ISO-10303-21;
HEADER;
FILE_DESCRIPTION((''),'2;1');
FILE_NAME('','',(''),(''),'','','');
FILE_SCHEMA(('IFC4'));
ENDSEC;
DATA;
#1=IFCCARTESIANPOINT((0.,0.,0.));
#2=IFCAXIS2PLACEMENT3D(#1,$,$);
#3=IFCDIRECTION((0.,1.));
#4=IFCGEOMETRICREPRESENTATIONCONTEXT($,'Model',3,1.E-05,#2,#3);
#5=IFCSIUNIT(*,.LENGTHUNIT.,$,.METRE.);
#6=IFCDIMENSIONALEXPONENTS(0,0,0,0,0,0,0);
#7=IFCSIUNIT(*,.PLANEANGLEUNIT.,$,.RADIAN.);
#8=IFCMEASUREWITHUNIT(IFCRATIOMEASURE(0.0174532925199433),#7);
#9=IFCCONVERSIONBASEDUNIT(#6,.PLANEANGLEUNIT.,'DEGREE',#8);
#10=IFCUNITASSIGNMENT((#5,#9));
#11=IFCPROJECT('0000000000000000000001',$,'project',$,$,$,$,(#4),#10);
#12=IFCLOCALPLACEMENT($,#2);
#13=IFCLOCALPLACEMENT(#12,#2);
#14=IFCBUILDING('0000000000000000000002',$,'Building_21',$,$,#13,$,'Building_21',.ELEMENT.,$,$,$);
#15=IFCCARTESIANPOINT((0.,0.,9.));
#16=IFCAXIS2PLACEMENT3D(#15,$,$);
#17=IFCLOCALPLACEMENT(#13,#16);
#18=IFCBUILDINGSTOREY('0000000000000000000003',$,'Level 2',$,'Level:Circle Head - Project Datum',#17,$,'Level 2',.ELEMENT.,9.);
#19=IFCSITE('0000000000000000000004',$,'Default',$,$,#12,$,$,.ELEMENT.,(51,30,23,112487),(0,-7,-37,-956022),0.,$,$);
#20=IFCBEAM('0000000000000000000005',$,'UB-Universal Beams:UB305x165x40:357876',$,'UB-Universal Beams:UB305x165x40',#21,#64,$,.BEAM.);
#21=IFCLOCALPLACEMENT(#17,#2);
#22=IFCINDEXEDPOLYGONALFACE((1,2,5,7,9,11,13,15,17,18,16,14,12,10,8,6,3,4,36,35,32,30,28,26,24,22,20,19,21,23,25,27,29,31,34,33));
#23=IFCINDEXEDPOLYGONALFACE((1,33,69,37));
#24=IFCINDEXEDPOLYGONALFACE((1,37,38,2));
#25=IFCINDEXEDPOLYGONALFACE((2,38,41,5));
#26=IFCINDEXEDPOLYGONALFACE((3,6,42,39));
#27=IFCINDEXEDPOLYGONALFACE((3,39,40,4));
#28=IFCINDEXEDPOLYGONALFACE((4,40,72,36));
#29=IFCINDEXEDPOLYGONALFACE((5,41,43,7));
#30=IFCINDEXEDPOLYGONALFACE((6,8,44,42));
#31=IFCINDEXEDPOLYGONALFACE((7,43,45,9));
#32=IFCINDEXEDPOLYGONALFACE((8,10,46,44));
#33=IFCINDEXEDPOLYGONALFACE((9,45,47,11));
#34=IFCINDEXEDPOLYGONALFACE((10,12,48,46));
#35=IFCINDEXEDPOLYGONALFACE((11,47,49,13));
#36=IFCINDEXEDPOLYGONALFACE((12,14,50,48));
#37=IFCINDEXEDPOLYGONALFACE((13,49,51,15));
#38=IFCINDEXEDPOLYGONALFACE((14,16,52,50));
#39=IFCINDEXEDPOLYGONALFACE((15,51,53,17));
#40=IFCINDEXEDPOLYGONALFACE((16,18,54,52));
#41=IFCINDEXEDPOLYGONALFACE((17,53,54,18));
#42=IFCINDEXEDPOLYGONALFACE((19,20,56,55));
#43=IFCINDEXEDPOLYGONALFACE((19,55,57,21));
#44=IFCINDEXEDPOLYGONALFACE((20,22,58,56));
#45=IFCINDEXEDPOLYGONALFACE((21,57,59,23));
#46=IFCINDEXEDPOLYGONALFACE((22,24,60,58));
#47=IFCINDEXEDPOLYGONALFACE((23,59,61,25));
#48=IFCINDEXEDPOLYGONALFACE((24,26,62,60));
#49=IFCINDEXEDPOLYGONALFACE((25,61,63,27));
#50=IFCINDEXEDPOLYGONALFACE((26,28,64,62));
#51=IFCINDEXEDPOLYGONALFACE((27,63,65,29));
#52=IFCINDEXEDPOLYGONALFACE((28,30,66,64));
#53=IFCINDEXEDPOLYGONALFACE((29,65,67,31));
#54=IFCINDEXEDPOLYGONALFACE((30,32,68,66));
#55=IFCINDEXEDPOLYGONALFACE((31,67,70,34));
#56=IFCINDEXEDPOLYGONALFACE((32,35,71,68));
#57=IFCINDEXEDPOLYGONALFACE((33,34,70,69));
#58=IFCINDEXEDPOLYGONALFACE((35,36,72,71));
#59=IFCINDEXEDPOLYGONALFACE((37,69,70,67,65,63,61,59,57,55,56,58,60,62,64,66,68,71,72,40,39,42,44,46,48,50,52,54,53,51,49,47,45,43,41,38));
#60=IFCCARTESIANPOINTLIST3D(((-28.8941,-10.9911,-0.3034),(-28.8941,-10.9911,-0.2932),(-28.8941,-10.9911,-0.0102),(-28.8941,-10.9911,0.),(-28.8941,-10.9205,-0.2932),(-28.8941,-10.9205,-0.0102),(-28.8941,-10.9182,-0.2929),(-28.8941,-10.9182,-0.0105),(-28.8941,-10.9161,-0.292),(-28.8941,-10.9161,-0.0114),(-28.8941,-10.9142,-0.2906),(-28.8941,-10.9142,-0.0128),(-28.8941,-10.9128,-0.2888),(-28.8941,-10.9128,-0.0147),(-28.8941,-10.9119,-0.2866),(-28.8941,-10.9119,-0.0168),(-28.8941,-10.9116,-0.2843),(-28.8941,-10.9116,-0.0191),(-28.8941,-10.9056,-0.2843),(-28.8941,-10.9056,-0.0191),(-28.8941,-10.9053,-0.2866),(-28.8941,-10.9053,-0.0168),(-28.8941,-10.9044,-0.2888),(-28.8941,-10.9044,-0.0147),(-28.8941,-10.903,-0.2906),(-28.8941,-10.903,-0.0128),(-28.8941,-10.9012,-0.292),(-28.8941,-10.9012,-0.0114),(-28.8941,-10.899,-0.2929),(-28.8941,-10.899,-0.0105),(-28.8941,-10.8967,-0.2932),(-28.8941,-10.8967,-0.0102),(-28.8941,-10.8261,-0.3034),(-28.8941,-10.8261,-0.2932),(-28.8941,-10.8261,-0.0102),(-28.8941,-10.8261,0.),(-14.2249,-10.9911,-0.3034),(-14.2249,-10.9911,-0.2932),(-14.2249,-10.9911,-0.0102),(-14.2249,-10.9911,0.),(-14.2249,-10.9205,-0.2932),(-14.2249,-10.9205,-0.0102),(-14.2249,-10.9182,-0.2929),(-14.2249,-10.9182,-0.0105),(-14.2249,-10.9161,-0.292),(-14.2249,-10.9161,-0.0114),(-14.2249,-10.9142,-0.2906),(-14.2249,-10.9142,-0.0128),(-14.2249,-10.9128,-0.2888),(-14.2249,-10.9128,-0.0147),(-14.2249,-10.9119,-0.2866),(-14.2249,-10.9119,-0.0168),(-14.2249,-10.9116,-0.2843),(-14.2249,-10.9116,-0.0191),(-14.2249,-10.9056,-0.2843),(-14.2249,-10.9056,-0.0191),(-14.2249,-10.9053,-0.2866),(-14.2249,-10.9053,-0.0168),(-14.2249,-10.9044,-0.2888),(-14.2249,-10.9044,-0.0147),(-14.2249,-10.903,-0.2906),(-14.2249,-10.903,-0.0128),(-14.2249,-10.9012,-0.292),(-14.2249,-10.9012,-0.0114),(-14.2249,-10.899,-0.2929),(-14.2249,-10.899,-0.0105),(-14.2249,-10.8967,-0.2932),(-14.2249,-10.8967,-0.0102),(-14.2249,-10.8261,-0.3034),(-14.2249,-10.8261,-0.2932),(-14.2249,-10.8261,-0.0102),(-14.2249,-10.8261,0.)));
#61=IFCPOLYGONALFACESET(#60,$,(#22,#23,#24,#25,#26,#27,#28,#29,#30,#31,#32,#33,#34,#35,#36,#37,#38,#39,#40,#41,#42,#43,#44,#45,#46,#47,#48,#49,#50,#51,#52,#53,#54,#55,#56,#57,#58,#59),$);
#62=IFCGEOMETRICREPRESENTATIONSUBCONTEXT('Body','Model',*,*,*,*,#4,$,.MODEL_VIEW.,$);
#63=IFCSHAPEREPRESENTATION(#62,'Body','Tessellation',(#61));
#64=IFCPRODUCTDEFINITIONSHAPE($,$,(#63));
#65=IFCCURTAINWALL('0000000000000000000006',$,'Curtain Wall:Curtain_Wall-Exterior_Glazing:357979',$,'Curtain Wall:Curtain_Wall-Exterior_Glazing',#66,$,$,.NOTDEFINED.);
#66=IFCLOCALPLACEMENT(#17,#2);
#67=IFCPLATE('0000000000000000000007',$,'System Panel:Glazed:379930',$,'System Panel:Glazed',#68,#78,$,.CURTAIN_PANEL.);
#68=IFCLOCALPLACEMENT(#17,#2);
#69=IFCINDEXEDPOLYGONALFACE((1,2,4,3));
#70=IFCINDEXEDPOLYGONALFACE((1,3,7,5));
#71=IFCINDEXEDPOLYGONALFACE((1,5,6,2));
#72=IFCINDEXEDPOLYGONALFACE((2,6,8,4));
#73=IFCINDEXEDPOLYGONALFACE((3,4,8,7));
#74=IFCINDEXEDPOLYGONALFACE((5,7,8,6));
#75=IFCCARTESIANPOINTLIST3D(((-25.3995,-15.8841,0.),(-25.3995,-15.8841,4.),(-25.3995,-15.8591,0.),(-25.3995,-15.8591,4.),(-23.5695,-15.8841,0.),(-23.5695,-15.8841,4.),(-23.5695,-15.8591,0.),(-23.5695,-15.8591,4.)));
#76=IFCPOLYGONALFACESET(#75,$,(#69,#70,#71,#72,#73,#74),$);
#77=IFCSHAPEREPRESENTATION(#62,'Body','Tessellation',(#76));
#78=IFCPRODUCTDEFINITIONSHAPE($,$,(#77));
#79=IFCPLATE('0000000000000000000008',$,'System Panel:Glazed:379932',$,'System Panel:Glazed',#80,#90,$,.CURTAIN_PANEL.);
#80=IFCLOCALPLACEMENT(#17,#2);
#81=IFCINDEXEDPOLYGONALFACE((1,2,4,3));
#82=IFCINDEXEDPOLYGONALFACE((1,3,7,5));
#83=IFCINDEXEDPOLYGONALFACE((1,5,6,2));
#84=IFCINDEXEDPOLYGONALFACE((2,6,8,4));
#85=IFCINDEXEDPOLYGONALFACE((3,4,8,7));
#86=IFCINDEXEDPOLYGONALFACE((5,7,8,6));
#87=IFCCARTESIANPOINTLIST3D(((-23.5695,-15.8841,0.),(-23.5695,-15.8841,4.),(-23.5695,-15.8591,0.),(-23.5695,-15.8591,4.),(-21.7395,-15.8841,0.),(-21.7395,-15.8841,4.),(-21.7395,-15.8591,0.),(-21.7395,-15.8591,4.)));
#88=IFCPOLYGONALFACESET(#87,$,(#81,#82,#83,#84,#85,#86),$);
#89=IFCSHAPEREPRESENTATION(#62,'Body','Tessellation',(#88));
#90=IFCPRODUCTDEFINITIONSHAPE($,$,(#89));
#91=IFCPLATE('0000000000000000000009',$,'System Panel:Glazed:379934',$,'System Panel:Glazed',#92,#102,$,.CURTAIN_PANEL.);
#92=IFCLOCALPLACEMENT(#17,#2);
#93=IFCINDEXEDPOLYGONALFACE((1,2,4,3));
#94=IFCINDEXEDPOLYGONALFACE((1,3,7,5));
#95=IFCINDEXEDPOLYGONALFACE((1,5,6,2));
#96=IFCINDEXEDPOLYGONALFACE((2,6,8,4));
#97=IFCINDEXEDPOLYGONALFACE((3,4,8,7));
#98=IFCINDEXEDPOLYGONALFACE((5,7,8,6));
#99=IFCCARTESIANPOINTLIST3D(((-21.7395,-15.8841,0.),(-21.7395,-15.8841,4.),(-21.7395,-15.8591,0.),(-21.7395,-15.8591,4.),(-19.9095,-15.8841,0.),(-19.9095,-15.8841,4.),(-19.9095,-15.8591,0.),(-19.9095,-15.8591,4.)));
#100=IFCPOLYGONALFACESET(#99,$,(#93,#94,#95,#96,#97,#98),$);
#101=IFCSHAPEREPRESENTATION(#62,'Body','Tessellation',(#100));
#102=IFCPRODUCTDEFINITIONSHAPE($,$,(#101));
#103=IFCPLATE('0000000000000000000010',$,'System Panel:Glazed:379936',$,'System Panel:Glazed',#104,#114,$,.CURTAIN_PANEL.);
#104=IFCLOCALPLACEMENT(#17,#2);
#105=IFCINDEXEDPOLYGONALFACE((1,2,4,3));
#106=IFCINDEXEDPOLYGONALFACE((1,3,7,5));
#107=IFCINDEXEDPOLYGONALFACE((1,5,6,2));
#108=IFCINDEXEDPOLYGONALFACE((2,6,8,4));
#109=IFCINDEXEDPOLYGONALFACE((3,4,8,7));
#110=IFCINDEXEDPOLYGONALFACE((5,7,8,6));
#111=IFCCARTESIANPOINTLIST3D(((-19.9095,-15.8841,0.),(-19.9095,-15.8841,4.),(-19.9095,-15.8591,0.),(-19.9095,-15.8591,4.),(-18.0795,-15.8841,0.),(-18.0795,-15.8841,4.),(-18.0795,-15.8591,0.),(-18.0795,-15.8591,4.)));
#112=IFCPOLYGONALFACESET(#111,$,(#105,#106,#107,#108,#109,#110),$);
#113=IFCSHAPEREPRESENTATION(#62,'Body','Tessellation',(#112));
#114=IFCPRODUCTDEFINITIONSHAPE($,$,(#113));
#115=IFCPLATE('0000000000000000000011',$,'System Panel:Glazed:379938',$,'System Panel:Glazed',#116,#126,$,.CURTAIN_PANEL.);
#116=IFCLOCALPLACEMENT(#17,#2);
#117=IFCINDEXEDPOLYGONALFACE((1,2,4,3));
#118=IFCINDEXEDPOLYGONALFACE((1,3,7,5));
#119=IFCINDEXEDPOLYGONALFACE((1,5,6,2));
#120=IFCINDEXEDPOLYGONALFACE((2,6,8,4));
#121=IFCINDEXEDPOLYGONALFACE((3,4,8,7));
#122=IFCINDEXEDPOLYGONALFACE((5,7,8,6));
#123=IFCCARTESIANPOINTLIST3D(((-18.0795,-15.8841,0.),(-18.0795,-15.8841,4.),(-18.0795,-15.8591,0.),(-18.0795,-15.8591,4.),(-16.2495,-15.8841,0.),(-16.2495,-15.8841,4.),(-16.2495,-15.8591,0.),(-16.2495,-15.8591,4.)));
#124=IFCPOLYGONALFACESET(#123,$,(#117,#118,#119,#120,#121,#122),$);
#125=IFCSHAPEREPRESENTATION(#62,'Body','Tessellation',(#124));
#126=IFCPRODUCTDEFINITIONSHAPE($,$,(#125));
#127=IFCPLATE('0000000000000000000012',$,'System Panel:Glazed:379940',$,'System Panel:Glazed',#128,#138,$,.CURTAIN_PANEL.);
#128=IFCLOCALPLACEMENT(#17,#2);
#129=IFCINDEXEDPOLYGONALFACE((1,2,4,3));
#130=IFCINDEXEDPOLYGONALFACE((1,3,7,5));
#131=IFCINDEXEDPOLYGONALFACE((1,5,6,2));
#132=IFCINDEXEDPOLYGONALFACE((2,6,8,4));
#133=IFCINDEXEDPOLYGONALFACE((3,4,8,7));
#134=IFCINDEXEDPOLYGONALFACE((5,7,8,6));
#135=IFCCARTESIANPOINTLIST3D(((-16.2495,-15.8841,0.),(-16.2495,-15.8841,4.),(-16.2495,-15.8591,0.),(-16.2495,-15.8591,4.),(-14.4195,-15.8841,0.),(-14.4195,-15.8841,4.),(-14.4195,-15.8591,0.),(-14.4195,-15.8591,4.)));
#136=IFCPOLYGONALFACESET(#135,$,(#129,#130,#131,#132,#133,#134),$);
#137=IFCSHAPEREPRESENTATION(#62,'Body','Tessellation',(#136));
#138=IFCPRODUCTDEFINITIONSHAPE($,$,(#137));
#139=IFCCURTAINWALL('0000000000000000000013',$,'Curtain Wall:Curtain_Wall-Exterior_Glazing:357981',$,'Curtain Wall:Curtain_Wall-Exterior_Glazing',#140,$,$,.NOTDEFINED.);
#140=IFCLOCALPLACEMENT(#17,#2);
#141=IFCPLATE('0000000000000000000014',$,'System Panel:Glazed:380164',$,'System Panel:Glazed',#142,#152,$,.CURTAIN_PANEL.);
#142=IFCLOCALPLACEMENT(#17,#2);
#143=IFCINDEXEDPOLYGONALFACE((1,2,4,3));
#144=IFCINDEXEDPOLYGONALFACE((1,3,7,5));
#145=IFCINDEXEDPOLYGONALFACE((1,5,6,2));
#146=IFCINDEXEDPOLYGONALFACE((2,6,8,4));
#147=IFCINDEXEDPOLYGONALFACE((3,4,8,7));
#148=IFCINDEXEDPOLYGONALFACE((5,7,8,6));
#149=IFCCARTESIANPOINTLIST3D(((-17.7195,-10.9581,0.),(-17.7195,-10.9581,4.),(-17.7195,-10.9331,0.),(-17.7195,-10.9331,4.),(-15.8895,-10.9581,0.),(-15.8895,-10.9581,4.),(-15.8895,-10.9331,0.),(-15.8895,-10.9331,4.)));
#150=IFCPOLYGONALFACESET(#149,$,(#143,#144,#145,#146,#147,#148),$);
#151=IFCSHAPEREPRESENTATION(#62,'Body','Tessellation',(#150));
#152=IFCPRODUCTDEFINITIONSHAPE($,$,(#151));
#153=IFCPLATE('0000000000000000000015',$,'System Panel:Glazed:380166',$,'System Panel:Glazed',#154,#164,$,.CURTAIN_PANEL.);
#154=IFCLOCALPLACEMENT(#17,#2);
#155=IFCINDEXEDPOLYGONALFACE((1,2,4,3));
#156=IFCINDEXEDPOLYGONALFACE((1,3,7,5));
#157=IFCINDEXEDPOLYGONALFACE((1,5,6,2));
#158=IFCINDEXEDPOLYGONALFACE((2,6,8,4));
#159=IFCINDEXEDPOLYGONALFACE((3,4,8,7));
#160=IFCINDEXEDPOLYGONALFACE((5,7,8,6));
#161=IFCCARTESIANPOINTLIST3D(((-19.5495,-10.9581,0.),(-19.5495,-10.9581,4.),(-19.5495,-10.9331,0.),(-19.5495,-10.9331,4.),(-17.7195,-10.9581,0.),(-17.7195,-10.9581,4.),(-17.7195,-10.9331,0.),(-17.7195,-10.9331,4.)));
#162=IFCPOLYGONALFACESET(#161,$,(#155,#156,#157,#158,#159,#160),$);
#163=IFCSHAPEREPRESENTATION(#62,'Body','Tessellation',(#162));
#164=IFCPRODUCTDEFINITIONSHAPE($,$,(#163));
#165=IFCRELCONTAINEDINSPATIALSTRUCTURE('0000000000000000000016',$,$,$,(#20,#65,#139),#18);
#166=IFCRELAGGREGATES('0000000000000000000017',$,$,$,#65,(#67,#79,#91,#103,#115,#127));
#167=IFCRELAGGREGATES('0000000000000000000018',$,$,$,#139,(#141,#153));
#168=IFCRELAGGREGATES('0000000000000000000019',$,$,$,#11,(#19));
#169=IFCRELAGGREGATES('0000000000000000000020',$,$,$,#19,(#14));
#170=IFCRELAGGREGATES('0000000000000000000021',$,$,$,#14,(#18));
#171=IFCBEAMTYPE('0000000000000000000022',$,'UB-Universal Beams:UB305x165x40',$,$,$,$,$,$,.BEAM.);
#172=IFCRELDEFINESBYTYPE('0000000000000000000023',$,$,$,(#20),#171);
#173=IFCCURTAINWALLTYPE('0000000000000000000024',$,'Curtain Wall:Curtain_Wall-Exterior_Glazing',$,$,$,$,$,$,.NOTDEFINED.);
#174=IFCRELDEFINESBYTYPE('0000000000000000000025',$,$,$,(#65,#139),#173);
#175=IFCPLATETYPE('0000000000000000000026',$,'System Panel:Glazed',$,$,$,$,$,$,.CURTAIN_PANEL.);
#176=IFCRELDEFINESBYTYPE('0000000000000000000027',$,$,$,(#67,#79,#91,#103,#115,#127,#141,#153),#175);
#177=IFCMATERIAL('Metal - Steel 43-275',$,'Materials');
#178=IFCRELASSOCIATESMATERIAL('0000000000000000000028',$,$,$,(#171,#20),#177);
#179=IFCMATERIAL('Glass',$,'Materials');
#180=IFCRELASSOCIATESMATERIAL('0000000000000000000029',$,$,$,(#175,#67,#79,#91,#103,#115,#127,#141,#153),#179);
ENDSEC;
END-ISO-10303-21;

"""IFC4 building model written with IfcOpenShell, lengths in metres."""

from ifc_helpers import new_model, entity, si_unit, converted_unit, direction, frame, frame_2d, origin, origin_2d_with_axis, place, context, subcontext, project, spatial, polyline, circle_curve, parameter, trimmed, segment, composite_curve, rectangle, i_section, outline, extrude, source, transform, mapped, material, material_profile, profile_set, profile_usage, type_object, type_shapes, element, aggregate, save


model = new_model("IFC4")

# Units and contexts
model_context = context("Model", 3, precision=1e-05, world=origin(), true_north=direction((0.0, 1.0)))
body_context = subcontext(model_context, "Body", "Model", "MODEL_VIEW")
ifc_project = project(units=[si_unit("LENGTHUNIT", "METRE"), converted_unit("PLANEANGLEUNIT", "DEGREE", entity("IfcRatioMeasure", 0.0174532925199433), si_unit("PLANEANGLEUNIT", "RADIAN"), dimensions=[0, 0, 0, 0, 0, 0, 0])], contexts=[model_context])

# Site, building, storey
site_placement = place(None, origin())
site = spatial("IfcSite", under=ifc_project, at=site_placement, Name="Default", CompositionType="ELEMENT", RefLatitude=(51, 30, 23, 112487), RefLongitude=(0, -7, -37, -956022), RefElevation=0.0)
building_placement = place(site_placement, origin())
building = spatial("IfcBuilding", under=site, at=building_placement, Name="Building_21", LongName="Building_21", CompositionType="ELEMENT")
storey_placement = place(building_placement, frame((0.0, 0.0, 9.0)))
storey = spatial("IfcBuildingStorey", under=building, at=storey_placement, Name="Level 2", ObjectType="Level:Circle Head - Project Datum", LongName="Level 2", CompositionType="ELEMENT", Elevation=9.0)

# Shared definitions
ifc_material_1 = material(Name="Metal - Steel 43-275", Category="Materials")

# Beam
ifc_material_profile_1 = material_profile(ifc_material_1, outline(composite_curve([segment(polyline([(0.0119, -0.1415, 0.0), (0.0825, -0.1415, 0.0)]), True, "CONTINUOUS"), segment(polyline([(0.0825, -0.1415, 0.0), (0.0825, -0.1517, 0.0)]), True, "CONTINUOUS"), segment(polyline([(0.0825, -0.1517, 0.0), (-0.0825, -0.1517, 0.0)]), True, "CONTINUOUS"), segment(polyline([(-0.0825, -0.1517, 0.0), (-0.0825, -0.1415, 0.0)]), True, "CONTINUOUS"), segment(polyline([(-0.0825, -0.1415, 0.0), (-0.0119, -0.1415, 0.0)]), True, "CONTINUOUS"), segment(trimmed(circle_curve(frame((-0.0119, -0.1326, 0.0), z_axis=(0.0, 0.0, 1.0), x_axis=(-1.0, 0.0, 0.0)), 0.0089), [parameter(90.0)], [parameter(180.0)], True, "PARAMETER"), True, "CONTINUOUS"), segment(polyline([(-0.003, -0.1326, 0.0), (-0.003, 0.1326, 0.0)]), True, "CONTINUOUS"), segment(trimmed(circle_curve(frame((-0.0119, 0.1326, 0.0), z_axis=(0.0, 0.0, 1.0), x_axis=(-1.0, 0.0, 0.0)), 0.0089), [parameter(180.0)], [parameter(270.0)], True, "PARAMETER"), True, "CONTINUOUS"), segment(polyline([(-0.0119, 0.1415, 0.0), (-0.0825, 0.1415, 0.0)]), True, "CONTINUOUS"), segment(polyline([(-0.0825, 0.1415, 0.0), (-0.0825, 0.1517, 0.0)]), True, "CONTINUOUS"), segment(polyline([(-0.0825, 0.1517, 0.0), (0.0825, 0.1517, 0.0)]), True, "CONTINUOUS"), segment(polyline([(0.0825, 0.1517, 0.0), (0.0825, 0.1415, 0.0)]), True, "CONTINUOUS"), segment(polyline([(0.0825, 0.1415, 0.0), (0.0119, 0.1415, 0.0)]), True, "CONTINUOUS"), segment(trimmed(circle_curve(frame((0.0119, 0.1326, 0.0), z_axis=(0.0, 0.0, 1.0), x_axis=(-1.0, 0.0, 0.0)), 0.0089), [parameter(270.0)], [parameter(0.0)], True, "PARAMETER"), True, "CONTINUOUS"), segment(polyline([(0.003, 0.1326, 0.0), (0.003, -0.1326, 0.0)]), True, "CONTINUOUS"), segment(trimmed(circle_curve(frame((0.0119, -0.1326, 0.0), z_axis=(0.0, 0.0, 1.0), x_axis=(-1.0, 0.0, 0.0)), 0.0089), [parameter(0.0)], [parameter(90.0)], True, "PARAMETER"), True, "CONTINUOUS")], self_intersect=False), kind="CURVE"), Name="UB305x165x40")
ifc_material_profile_2 = material_profile(ifc_material_1, outline(composite_curve([segment(polyline([(-1.3346, 0.0825, -0.1415), (-1.3346, 0.0825, -0.1517)]), True, "CONTINUOUS"), segment(polyline([(-1.3346, 0.0825, -0.1517), (-1.3346, -0.0825, -0.1517)]), True, "CONTINUOUS"), segment(polyline([(-1.3346, -0.0825, -0.1517), (-1.3346, -0.0825, -0.1415)]), True, "CONTINUOUS"), segment(polyline([(-1.3346, -0.0825, -0.1415), (-1.3346, -0.003, -0.1415)]), True, "CONTINUOUS"), segment(polyline([(-1.3346, -0.003, -0.1415), (-1.3346, -0.003, 0.1415)]), True, "CONTINUOUS"), segment(polyline([(-1.3346, -0.003, 0.1415), (-1.3346, -0.0825, 0.1415)]), True, "CONTINUOUS"), segment(polyline([(-1.3346, -0.0825, 0.1415), (-1.3346, -0.0825, 0.1517)]), True, "CONTINUOUS"), segment(polyline([(-1.3346, -0.0825, 0.1517), (-1.3346, 0.0825, 0.1517)]), True, "CONTINUOUS"), segment(polyline([(-1.3346, 0.0825, 0.1517), (-1.3346, 0.0825, 0.1415)]), True, "CONTINUOUS"), segment(polyline([(-1.3346, 0.0825, 0.1415), (-1.3346, 0.003, 0.1415)]), True, "CONTINUOUS"), segment(polyline([(-1.3346, 0.003, 0.1415), (-1.3346, 0.003, -0.1415)]), True, "CONTINUOUS"), segment(polyline([(-1.3346, 0.003, -0.1415), (-1.3346, 0.0825, -0.1415)]), True, "CONTINUOUS")], self_intersect=False), kind="CURVE"), Name="UB305x165x40")
ifc_profile_set_1 = profile_set([ifc_material_profile_1, ifc_material_profile_2], Name="UB305x165x40")
ifc_profile_usage_1 = profile_usage(ifc_profile_set_1, cardinal=8)
beam_type_1 = type_object("IfcBeamType", Name="UB-Universal Beams:UB305x165x40", PredefinedType="BEAM", material=ifc_profile_set_1)
shared_shape_1 = source(origin(), body_context, "Body", "SweptSolid", [
    extrude(i_section(OverallWidth=0.165, OverallDepth=0.3034, WebThickness=0.006, FlangeThickness=0.0102, FilletRadius=0.0089, at=frame_2d((0.0, 0.0), x_axis=(0.0, 1.0))), frame((-7.3346, 0.0, 0.0), z_axis=(1.0, 0.0, 0.0), x_axis=(0.0, 0.0, -1.0)), (0.0, 0.0, 1.0), 14.6692),
])
type_shapes(beam_type_1, [shared_shape_1])
beam_1_placement = place(storey_placement, frame((-21.5595, -10.9086, -0.1517), z_axis=(0.0, 0.0, 1.0), x_axis=(-1.0, 0.0, 0.0)))
element("IfcBeam", 1, at=beam_1_placement, inside=storey, type_object=beam_type_1, material=ifc_profile_usage_1, Name="UB-Universal Beams:UB305x165x40:357876", ObjectType="UB-Universal Beams:UB305x165x40", PredefinedType="BEAM", context=body_context, shape_type="MappedRepresentation", body=[
    mapped(shared_shape_1, transform((0.0, 0.0, 0.0), scale=1.0)),
])

# Curtain walls, plates
curtain_wall_type = type_object("IfcCurtainWallType", Name="Curtain Wall:Curtain_Wall-Exterior_Glazing", PredefinedType="NOTDEFINED")
curtain_wall_1_placement = place(storey_placement, frame((0.0, 0.0, -9.0)))
curtain_wall_1 = element("IfcCurtainWall", 2, at=curtain_wall_1_placement, inside=storey, type_object=curtain_wall_type, Name="Curtain Wall:Curtain_Wall-Exterior_Glazing:357979", ObjectType="Curtain Wall:Curtain_Wall-Exterior_Glazing", PredefinedType="NOTDEFINED")
ifc_material_2 = material(Name="Glass", Category="Materials")
plate_type = type_object("IfcPlateType", Name="System Panel:Glazed", PredefinedType="CURTAIN_PANEL", material=ifc_material_2)
shared_shape_2 = source(origin(), body_context, "Body", "SweptSolid", [
    extrude(rectangle(XDim=0.025, YDim=1.83, at=origin_2d_with_axis()), frame((0.915, 0.0125, 0.0), z_axis=(0.0, 0.0, 1.0), x_axis=(0.0, 1.0, 0.0)), (0.0, 0.0, 1.0), 4.0),
])
type_shapes(plate_type, [shared_shape_2])
plate_1_placement = place(curtain_wall_1_placement, frame((-25.3995, -15.8841, 9.0)))
plate_1 = element("IfcPlate", 3, at=plate_1_placement, type_object=plate_type, material=ifc_material_2, Name="System Panel:Glazed:379930", ObjectType="System Panel:Glazed", PredefinedType="CURTAIN_PANEL", context=body_context, shape_type="MappedRepresentation", body=[
    mapped(shared_shape_2, transform((0.0, 0.0, 0.0), scale=1.0)),
])
plate_2_placement = place(curtain_wall_1_placement, frame((-23.5695, -15.8841, 9.0)))
plate_2 = element("IfcPlate", 4, at=plate_2_placement, type_object=plate_type, material=ifc_material_2, Name="System Panel:Glazed:379932", ObjectType="System Panel:Glazed", PredefinedType="CURTAIN_PANEL", context=body_context, shape_type="MappedRepresentation", body=[
    mapped(shared_shape_2, transform((0.0, 0.0, 0.0), scale=1.0)),
])
plate_3_placement = place(curtain_wall_1_placement, frame((-21.7395, -15.8841, 9.0)))
plate_3 = element("IfcPlate", 5, at=plate_3_placement, type_object=plate_type, material=ifc_material_2, Name="System Panel:Glazed:379934", ObjectType="System Panel:Glazed", PredefinedType="CURTAIN_PANEL", context=body_context, shape_type="MappedRepresentation", body=[
    mapped(shared_shape_2, transform((0.0, 0.0, 0.0), scale=1.0)),
])
plate_4_placement = place(curtain_wall_1_placement, frame((-19.9095, -15.8841, 9.0)))
plate_4 = element("IfcPlate", 6, at=plate_4_placement, type_object=plate_type, material=ifc_material_2, Name="System Panel:Glazed:379936", ObjectType="System Panel:Glazed", PredefinedType="CURTAIN_PANEL", context=body_context, shape_type="MappedRepresentation", body=[
    mapped(shared_shape_2, transform((0.0, 0.0, 0.0), scale=1.0)),
])
plate_5_placement = place(curtain_wall_1_placement, frame((-18.0795, -15.8841, 9.0)))
plate_5 = element("IfcPlate", 7, at=plate_5_placement, type_object=plate_type, material=ifc_material_2, Name="System Panel:Glazed:379938", ObjectType="System Panel:Glazed", PredefinedType="CURTAIN_PANEL", context=body_context, shape_type="MappedRepresentation", body=[
    mapped(shared_shape_2, transform((0.0, 0.0, 0.0), scale=1.0)),
])
plate_6_placement = place(curtain_wall_1_placement, frame((-16.2495, -15.8841, 9.0)))
plate_6 = element("IfcPlate", 8, at=plate_6_placement, type_object=plate_type, material=ifc_material_2, Name="System Panel:Glazed:379940", ObjectType="System Panel:Glazed", PredefinedType="CURTAIN_PANEL", context=body_context, shape_type="MappedRepresentation", body=[
    mapped(shared_shape_2, transform((0.0, 0.0, 0.0), scale=1.0)),
])
aggregate(curtain_wall_1, [plate_1, plate_2, plate_3, plate_4, plate_5, plate_6])
curtain_wall_2_placement = place(storey_placement, frame((0.0, 0.0, -9.0)))
curtain_wall_2 = element("IfcCurtainWall", 9, at=curtain_wall_2_placement, inside=storey, type_object=curtain_wall_type, Name="Curtain Wall:Curtain_Wall-Exterior_Glazing:357981", ObjectType="Curtain Wall:Curtain_Wall-Exterior_Glazing", PredefinedType="NOTDEFINED")
plate_7_placement = place(curtain_wall_2_placement, frame((-15.8895, -10.9331, 9.0), z_axis=(0.0, 0.0, 1.0), x_axis=(-1.0, 0.0, 0.0)))
plate_7 = element("IfcPlate", 10, at=plate_7_placement, type_object=plate_type, material=ifc_material_2, Name="System Panel:Glazed:380164", ObjectType="System Panel:Glazed", PredefinedType="CURTAIN_PANEL", context=body_context, shape_type="MappedRepresentation", body=[
    mapped(shared_shape_2, transform((0.0, 0.0, 0.0), scale=1.0)),
])
plate_8_placement = place(curtain_wall_2_placement, frame((-17.7195, -10.9331, 9.0), z_axis=(0.0, 0.0, 1.0), x_axis=(-1.0, 0.0, 0.0)))
plate_8 = element("IfcPlate", 11, at=plate_8_placement, type_object=plate_type, material=ifc_material_2, Name="System Panel:Glazed:380166", ObjectType="System Panel:Glazed", PredefinedType="CURTAIN_PANEL", context=body_context, shape_type="MappedRepresentation", body=[
    mapped(shared_shape_2, transform((0.0, 0.0, 0.0), scale=1.0)),
])
aggregate(curtain_wall_2, [plate_7, plate_8])

save(model, "model.ifc")
